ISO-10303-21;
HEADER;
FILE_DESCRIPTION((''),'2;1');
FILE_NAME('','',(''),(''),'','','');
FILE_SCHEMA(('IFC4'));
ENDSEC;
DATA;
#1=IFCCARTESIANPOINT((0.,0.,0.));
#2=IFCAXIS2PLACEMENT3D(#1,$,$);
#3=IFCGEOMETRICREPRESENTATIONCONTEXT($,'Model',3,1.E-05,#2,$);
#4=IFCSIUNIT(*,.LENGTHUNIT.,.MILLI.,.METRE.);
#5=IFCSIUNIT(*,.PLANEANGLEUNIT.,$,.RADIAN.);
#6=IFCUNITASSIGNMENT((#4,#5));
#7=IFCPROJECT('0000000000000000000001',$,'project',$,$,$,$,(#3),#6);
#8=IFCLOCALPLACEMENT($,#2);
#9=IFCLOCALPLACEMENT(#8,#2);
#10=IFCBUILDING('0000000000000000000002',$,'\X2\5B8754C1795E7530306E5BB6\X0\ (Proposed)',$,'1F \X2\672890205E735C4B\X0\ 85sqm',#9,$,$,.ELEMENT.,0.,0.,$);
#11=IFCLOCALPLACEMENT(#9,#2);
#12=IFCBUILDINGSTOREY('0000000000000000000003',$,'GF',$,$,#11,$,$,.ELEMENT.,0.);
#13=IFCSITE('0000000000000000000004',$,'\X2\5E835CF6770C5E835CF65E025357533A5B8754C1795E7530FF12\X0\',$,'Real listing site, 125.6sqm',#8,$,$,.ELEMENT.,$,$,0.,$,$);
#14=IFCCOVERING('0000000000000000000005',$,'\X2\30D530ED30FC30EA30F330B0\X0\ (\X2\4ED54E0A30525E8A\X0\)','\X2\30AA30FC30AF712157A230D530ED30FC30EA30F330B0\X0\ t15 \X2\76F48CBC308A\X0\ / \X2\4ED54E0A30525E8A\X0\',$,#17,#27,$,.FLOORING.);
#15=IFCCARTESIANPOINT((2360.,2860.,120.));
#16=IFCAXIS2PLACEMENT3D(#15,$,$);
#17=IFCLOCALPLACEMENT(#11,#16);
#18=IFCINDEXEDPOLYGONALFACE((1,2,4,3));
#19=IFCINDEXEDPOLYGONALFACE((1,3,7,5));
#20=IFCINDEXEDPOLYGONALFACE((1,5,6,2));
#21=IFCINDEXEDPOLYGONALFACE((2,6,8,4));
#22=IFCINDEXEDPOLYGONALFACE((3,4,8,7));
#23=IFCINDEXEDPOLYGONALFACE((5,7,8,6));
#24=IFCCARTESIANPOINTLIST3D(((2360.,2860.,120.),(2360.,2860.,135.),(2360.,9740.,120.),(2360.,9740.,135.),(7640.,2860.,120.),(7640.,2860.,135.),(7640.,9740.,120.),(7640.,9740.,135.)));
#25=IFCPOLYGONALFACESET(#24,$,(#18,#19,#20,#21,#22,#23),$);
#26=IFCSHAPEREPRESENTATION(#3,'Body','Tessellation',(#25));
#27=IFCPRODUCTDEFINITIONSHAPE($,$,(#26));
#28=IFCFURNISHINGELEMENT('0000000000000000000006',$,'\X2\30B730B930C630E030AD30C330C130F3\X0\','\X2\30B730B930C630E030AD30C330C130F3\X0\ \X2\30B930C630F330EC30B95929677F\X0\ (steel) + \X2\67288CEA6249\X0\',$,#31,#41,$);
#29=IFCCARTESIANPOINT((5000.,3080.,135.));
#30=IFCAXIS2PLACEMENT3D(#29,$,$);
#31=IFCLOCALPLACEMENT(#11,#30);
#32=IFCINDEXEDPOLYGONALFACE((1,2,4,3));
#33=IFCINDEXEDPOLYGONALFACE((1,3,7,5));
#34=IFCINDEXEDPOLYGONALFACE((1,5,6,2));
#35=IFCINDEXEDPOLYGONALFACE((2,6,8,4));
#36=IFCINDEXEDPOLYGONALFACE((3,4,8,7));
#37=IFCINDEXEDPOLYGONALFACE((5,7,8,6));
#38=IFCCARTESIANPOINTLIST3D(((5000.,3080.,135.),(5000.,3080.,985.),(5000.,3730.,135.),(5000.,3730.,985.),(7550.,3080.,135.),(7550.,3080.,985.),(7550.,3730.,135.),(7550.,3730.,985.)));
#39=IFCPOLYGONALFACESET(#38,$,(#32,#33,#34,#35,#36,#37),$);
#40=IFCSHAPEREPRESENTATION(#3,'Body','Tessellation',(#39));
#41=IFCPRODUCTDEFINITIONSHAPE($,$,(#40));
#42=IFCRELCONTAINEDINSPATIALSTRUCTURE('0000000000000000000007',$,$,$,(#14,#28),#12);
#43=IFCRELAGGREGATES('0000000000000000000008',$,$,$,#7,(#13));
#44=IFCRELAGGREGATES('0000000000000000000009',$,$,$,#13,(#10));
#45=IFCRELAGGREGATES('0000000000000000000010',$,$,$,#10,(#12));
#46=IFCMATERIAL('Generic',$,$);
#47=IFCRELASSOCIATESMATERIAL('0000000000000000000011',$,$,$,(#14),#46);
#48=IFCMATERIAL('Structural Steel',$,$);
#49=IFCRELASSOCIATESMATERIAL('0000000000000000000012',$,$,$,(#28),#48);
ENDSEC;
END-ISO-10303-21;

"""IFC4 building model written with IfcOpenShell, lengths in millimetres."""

from ifc_helpers import new_model, si_unit, frame, frame_2d, origin, place, context, project, spatial, rectangle, extrude, material, element, save


model = new_model("IFC4")

# Units and contexts
model_context = context("Model", 3, precision=1e-05, world=origin())
ifc_project = project(units=[si_unit("LENGTHUNIT", "METRE", prefix="MILLI"), si_unit("PLANEANGLEUNIT", "RADIAN")], contexts=[model_context])

# Site, building, storey
site_placement = place(None, origin())
site = spatial("IfcSite", under=ifc_project, at=site_placement, Name="広島県広島市南区宇品神田２", ObjectType="Real listing site, 125.6sqm", CompositionType="ELEMENT", RefElevation=0.0)
building_placement = place(site_placement, origin())
building = spatial("IfcBuilding", under=site, at=building_placement, Name="宇品神田の家 (Proposed)", ObjectType="1F 木造平屋 85sqm", CompositionType="ELEMENT", ElevationOfRefHeight=0.0, ElevationOfTerrain=0.0)
storey_placement = place(building_placement, origin())
storey = spatial("IfcBuildingStorey", under=building, at=storey_placement, Name="GF", CompositionType="ELEMENT", Elevation=0.0)

# Shared definitions
ifc_material_1 = material(Name="Generic")

# Covering
covering_placement = place(storey_placement, frame((2360.0, 2860.0, 120.0)))
element("IfcCovering", 1, at=covering_placement, inside=storey, material=ifc_material_1, Name="フローリング (仕上げ床)", Description="オーク無垢フローリング t15 直貼り / 仕上げ床", PredefinedType="FLOORING", context=model_context, shape_type="SweptSolid", body=[
    extrude(rectangle(XDim=5280.0, YDim=6880.0, at=frame_2d((2640.0, 3440.0))), frame((2360.0, 2860.0, 120.0)), (0.0, 0.0, 1.0), 15.0),
])

# Furnishing element
ifc_material_2 = material(Name="Structural Steel")
furnishing_placement = place(storey_placement, frame((5000.0, 3080.0, 135.0)))
element("IfcFurnishingElement", 2, at=furnishing_placement, inside=storey, material=ifc_material_2, Name="システムキッチン", Description="システムキッチン ステンレス天板 (steel) + 木質扉", context=model_context, shape_type="SweptSolid", body=[
    extrude(rectangle(XDim=2550.0, YDim=650.0, at=frame_2d((1275.0, 325.0))), frame((5000.0, 3080.0, 135.0)), (0.0, 0.0, 1.0), 850.0),
])

save(model, "model.ifc")
